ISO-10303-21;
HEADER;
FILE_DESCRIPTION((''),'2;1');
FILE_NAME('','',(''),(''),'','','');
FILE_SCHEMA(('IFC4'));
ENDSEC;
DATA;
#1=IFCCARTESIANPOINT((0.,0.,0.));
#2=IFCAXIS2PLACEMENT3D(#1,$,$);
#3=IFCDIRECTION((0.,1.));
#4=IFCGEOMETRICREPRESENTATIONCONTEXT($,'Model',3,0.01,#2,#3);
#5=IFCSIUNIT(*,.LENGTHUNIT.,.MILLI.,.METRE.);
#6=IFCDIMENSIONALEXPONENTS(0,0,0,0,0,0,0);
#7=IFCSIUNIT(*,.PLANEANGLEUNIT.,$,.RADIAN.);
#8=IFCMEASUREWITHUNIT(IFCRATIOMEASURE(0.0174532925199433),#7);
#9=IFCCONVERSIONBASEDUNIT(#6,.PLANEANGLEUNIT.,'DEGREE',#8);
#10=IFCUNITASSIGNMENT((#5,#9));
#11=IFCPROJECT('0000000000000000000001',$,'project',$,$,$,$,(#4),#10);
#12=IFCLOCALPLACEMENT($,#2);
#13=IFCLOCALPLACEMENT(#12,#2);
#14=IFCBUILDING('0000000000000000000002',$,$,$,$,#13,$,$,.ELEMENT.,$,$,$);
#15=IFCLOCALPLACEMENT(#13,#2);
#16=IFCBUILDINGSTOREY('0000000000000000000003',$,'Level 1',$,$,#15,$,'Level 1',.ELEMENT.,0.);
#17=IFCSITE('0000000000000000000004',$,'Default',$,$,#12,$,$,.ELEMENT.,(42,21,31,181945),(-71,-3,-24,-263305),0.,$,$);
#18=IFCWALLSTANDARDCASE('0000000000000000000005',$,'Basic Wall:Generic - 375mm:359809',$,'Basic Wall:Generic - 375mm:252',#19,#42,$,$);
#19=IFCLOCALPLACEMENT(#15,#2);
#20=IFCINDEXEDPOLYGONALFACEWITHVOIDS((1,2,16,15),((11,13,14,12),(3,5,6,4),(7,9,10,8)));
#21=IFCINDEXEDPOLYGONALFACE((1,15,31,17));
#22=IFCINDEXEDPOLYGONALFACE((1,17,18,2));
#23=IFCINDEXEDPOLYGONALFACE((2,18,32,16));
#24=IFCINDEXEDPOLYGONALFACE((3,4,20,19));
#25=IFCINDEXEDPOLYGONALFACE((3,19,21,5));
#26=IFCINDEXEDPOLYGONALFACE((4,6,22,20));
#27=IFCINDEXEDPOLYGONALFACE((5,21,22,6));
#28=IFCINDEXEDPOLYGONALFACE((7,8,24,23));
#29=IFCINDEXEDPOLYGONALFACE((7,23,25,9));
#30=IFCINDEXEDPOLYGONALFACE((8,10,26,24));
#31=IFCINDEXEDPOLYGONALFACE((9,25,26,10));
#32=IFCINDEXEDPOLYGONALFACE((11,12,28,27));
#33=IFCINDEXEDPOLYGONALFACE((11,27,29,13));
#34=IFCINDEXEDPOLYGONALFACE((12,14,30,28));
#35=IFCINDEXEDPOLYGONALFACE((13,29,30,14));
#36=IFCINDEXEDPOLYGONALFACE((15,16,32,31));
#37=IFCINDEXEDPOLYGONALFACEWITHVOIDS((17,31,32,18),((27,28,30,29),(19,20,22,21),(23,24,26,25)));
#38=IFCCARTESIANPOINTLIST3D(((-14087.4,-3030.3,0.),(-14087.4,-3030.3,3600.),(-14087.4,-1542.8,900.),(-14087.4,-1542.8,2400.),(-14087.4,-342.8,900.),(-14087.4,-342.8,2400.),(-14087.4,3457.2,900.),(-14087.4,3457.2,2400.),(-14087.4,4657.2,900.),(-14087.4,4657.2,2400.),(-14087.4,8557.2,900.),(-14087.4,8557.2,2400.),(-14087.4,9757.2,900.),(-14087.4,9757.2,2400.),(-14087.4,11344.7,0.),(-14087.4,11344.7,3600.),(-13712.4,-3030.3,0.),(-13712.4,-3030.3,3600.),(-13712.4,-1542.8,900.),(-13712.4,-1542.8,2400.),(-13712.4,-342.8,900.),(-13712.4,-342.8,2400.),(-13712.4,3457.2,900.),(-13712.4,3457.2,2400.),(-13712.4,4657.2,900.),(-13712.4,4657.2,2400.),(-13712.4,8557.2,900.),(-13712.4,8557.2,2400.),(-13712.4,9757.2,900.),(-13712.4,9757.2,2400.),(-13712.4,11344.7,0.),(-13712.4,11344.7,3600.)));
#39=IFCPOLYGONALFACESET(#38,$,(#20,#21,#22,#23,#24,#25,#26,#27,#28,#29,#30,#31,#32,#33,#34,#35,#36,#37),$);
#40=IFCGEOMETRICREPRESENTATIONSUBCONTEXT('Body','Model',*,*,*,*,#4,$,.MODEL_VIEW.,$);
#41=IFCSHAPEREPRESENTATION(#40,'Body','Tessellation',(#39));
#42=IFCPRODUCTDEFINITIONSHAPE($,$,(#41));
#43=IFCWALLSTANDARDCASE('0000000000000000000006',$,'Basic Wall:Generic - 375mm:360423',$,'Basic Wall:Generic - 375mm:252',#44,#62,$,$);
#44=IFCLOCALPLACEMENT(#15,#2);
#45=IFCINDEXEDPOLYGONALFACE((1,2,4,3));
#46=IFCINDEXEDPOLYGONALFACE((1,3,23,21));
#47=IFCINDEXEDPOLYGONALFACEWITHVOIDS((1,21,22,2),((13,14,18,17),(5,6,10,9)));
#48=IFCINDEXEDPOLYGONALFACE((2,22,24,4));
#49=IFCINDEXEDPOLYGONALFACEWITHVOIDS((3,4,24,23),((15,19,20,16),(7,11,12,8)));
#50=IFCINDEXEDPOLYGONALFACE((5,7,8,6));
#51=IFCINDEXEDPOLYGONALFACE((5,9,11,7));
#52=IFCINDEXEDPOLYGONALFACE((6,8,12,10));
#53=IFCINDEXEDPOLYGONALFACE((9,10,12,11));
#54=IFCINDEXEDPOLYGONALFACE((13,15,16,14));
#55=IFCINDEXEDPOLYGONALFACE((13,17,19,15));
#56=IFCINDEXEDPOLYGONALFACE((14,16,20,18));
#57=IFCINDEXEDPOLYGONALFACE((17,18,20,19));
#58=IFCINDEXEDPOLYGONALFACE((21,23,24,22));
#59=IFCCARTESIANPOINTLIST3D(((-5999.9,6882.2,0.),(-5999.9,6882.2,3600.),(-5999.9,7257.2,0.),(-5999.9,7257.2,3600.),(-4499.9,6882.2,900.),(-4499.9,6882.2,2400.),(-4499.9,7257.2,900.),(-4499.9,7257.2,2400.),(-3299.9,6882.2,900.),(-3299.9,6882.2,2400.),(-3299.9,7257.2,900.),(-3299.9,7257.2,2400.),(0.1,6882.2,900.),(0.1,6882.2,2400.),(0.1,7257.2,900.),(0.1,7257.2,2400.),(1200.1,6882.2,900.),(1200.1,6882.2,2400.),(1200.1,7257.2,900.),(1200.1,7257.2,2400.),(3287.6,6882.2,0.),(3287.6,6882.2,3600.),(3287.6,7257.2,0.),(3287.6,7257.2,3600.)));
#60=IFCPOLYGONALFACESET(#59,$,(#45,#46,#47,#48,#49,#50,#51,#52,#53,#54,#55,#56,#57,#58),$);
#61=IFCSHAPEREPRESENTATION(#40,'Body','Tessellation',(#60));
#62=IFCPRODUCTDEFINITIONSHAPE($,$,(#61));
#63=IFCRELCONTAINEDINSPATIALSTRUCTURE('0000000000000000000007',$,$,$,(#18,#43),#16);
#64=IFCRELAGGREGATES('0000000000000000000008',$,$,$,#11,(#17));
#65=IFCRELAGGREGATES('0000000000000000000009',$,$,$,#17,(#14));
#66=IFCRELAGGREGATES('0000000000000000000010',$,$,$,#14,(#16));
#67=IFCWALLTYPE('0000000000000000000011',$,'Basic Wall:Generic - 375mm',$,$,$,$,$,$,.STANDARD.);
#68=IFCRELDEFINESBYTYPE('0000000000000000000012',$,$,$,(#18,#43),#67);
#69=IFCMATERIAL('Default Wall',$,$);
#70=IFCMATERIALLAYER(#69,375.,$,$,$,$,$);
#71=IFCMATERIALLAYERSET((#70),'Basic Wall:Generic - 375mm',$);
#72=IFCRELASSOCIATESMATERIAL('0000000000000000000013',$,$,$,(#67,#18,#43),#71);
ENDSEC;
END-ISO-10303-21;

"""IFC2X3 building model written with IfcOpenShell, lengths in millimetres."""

from ifc_helpers import new_model, entity, si_unit, converted_unit, direction, frame, frame_2d, origin, place, context, subcontext, project, spatial, polyline, rectangle, extrude, clip, bounded_halfspace, material, layer, layer_set, layer_usage, type_object, element, save


model = new_model("IFC2X3")

# Units and contexts
model_context = context("Model", 3, precision=0.01, world=origin(), true_north=direction((0.0, 1.0)))
body_context = subcontext(model_context, "Body", "Model", "MODEL_VIEW")
ifc_project = project(units=[si_unit("LENGTHUNIT", "METRE", prefix="MILLI"), converted_unit("PLANEANGLEUNIT", "DEGREE", entity("IfcRatioMeasure", 0.0174532925199433), si_unit("PLANEANGLEUNIT", "RADIAN"), dimensions=[0, 0, 0, 0, 0, 0, 0])], contexts=[model_context])

# Site, building, storey
site_placement = place(None, origin())
site = spatial("IfcSite", under=ifc_project, at=site_placement, Name="Default", CompositionType="ELEMENT", RefLatitude=(42, 21, 31, 181945), RefLongitude=(-71, -3, -24, -263305), RefElevation=0.0)
building_placement = place(site_placement, origin())
building = spatial("IfcBuilding", under=site, at=building_placement, CompositionType="ELEMENT")
storey_placement = place(building_placement, origin())
storey = spatial("IfcBuildingStorey", under=building, at=storey_placement, Name="Level 1", LongName="Level 1", CompositionType="ELEMENT", Elevation=0.0)

# Walls, openings
ifc_material_1 = material(Name="Default Wall")
ifc_layer_1 = layer(ifc_material_1, 375.0)
ifc_layer_set_1 = layer_set([ifc_layer_1], Name="Basic Wall:Generic - 375mm")
ifc_layer_usage_1 = layer_usage(ifc_layer_set_1, "AXIS2", "NEGATIVE", 187.5)
wall_type_1 = type_object("IfcWallType", Name="Basic Wall:Generic - 375mm", PredefinedType="STANDARD", material=ifc_layer_set_1)
wall_1_placement = place(storey_placement, frame((-13899.9, 11344.7, 0.0), z_axis=(0.0, 0.0, 1.0), x_axis=(0.0, -1.0, 0.0)))
wall_1 = element("IfcWallStandardCase", 1, at=wall_1_placement, inside=storey, type_object=wall_type_1, material=ifc_layer_usage_1, Name="Basic Wall:Generic - 375mm:359809", ObjectType="Basic Wall:Generic - 375mm:252", context=body_context, shape_type="Clipping", body=[
    clip(extrude(rectangle(XDim=14375.0, YDim=375.0, at=frame_2d((7187.5, 0.0), x_axis=(-1.0, 0.0))), origin(), (0.0, 0.0, 1.0), 3600.0), bounded_halfspace(frame((0.0, -187.5, 3600.0), z_axis=(0.0, 0.0, -1.0), x_axis=(0.0, 1.0, 0.0)), True, frame((0.0, -187.5, 3600.0)), polyline([(0.0, 0.0), (14375.0, 0.0), (14375.0, 375.0), (14000.0, 375.0), (10487.5, 375.0), (10287.5, 375.0), (4287.5, 375.0), (4087.5, 375.0), (375.0, 375.0), (0.0, 375.0), (0.0, 0.0)]))),
])
opening_1_placement = place(wall_1_placement, frame((1587.5, -187.5, 900.0)))
element("IfcOpeningElement", 2, at=opening_1_placement, cuts=wall_1, ObjectType="Opening", context=body_context, shape_type="SweptSolid", body=[
    extrude(rectangle(XDim=1500.0, YDim=1200.0, at=frame_2d((750.0, 600.0), x_axis=(-1.0, 0.0))), frame((0.0, 0.0, 0.0), z_axis=(0.0, 1.0, 0.0), x_axis=(0.0, 0.0, 1.0)), (0.0, 0.0, 1.0), 375.0),
])
opening_2_placement = place(wall_1_placement, frame((6687.5, -187.5, 900.0)))
element("IfcOpeningElement", 3, at=opening_2_placement, cuts=wall_1, ObjectType="Opening", context=body_context, shape_type="SweptSolid", body=[
    extrude(rectangle(XDim=1500.0, YDim=1200.0, at=frame_2d((750.0, 600.0), x_axis=(-1.0, 0.0))), frame((0.0, 0.0, 0.0), z_axis=(0.0, 1.0, 0.0), x_axis=(0.0, 0.0, 1.0)), (0.0, 0.0, 1.0), 375.0),
])
opening_3_placement = place(wall_1_placement, frame((11687.5, -187.5, 900.0)))
element("IfcOpeningElement", 4, at=opening_3_placement, cuts=wall_1, ObjectType="Opening", context=body_context, shape_type="SweptSolid", body=[
    extrude(rectangle(XDim=1500.0, YDim=1200.0, at=frame_2d((750.0, 600.0), x_axis=(-1.0, 0.0))), frame((0.0, 0.0, 0.0), z_axis=(0.0, 1.0, 0.0), x_axis=(0.0, 0.0, 1.0)), (0.0, 0.0, 1.0), 375.0),
])
ifc_layer_usage_2 = layer_usage(ifc_layer_set_1, "AXIS2", "NEGATIVE", 187.5)
wall_2_placement = place(storey_placement, frame((-5999.9, 7069.7, 0.0)))
wall_2 = element("IfcWallStandardCase", 5, at=wall_2_placement, inside=storey, type_object=wall_type_1, material=ifc_layer_usage_2, Name="Basic Wall:Generic - 375mm:360423", ObjectType="Basic Wall:Generic - 375mm:252", context=body_context, shape_type="Clipping", body=[
    clip(extrude(rectangle(XDim=9287.5, YDim=375.0, at=frame_2d((4643.8, 0.0), x_axis=(-1.0, 0.0))), origin(), (0.0, 0.0, 1.0), 3600.0), bounded_halfspace(frame((0.0, -187.5, 3600.0), z_axis=(0.0, 0.0, -1.0), x_axis=(1.0, 0.0, 0.0)), True, frame((0.0, -187.5, 3600.0)), polyline([(0.0, 0.0), (375.0, 0.0), (9287.5, 0.0), (9287.5, 375.0), (8912.5, 375.0), (4200.0, 375.0), (4000.0, 375.0), (0.0, 375.0), (0.0, 175.0), (0.0, 0.0)]))),
])
opening_4_placement = place(wall_2_placement, frame((1500.0, -187.5, 900.0)))
element("IfcOpeningElement", 6, at=opening_4_placement, cuts=wall_2, ObjectType="Opening", context=body_context, shape_type="SweptSolid", body=[
    extrude(rectangle(XDim=1500.0, YDim=1200.0, at=frame_2d((750.0, 600.0), x_axis=(-1.0, 0.0))), frame((0.0, 0.0, 0.0), z_axis=(0.0, 1.0, 0.0), x_axis=(0.0, 0.0, 1.0)), (0.0, 0.0, 1.0), 375.0),
])
opening_5_placement = place(wall_2_placement, frame((6000.0, -187.5, 900.0)))
element("IfcOpeningElement", 7, at=opening_5_placement, cuts=wall_2, ObjectType="Opening", context=body_context, shape_type="SweptSolid", body=[
    extrude(rectangle(XDim=1500.0, YDim=1200.0, at=frame_2d((750.0, 600.0), x_axis=(-1.0, 0.0))), frame((0.0, 0.0, 0.0), z_axis=(0.0, 1.0, 0.0), x_axis=(0.0, 0.0, 1.0)), (0.0, 0.0, 1.0), 375.0),
])

save(model, "model.ifc")
